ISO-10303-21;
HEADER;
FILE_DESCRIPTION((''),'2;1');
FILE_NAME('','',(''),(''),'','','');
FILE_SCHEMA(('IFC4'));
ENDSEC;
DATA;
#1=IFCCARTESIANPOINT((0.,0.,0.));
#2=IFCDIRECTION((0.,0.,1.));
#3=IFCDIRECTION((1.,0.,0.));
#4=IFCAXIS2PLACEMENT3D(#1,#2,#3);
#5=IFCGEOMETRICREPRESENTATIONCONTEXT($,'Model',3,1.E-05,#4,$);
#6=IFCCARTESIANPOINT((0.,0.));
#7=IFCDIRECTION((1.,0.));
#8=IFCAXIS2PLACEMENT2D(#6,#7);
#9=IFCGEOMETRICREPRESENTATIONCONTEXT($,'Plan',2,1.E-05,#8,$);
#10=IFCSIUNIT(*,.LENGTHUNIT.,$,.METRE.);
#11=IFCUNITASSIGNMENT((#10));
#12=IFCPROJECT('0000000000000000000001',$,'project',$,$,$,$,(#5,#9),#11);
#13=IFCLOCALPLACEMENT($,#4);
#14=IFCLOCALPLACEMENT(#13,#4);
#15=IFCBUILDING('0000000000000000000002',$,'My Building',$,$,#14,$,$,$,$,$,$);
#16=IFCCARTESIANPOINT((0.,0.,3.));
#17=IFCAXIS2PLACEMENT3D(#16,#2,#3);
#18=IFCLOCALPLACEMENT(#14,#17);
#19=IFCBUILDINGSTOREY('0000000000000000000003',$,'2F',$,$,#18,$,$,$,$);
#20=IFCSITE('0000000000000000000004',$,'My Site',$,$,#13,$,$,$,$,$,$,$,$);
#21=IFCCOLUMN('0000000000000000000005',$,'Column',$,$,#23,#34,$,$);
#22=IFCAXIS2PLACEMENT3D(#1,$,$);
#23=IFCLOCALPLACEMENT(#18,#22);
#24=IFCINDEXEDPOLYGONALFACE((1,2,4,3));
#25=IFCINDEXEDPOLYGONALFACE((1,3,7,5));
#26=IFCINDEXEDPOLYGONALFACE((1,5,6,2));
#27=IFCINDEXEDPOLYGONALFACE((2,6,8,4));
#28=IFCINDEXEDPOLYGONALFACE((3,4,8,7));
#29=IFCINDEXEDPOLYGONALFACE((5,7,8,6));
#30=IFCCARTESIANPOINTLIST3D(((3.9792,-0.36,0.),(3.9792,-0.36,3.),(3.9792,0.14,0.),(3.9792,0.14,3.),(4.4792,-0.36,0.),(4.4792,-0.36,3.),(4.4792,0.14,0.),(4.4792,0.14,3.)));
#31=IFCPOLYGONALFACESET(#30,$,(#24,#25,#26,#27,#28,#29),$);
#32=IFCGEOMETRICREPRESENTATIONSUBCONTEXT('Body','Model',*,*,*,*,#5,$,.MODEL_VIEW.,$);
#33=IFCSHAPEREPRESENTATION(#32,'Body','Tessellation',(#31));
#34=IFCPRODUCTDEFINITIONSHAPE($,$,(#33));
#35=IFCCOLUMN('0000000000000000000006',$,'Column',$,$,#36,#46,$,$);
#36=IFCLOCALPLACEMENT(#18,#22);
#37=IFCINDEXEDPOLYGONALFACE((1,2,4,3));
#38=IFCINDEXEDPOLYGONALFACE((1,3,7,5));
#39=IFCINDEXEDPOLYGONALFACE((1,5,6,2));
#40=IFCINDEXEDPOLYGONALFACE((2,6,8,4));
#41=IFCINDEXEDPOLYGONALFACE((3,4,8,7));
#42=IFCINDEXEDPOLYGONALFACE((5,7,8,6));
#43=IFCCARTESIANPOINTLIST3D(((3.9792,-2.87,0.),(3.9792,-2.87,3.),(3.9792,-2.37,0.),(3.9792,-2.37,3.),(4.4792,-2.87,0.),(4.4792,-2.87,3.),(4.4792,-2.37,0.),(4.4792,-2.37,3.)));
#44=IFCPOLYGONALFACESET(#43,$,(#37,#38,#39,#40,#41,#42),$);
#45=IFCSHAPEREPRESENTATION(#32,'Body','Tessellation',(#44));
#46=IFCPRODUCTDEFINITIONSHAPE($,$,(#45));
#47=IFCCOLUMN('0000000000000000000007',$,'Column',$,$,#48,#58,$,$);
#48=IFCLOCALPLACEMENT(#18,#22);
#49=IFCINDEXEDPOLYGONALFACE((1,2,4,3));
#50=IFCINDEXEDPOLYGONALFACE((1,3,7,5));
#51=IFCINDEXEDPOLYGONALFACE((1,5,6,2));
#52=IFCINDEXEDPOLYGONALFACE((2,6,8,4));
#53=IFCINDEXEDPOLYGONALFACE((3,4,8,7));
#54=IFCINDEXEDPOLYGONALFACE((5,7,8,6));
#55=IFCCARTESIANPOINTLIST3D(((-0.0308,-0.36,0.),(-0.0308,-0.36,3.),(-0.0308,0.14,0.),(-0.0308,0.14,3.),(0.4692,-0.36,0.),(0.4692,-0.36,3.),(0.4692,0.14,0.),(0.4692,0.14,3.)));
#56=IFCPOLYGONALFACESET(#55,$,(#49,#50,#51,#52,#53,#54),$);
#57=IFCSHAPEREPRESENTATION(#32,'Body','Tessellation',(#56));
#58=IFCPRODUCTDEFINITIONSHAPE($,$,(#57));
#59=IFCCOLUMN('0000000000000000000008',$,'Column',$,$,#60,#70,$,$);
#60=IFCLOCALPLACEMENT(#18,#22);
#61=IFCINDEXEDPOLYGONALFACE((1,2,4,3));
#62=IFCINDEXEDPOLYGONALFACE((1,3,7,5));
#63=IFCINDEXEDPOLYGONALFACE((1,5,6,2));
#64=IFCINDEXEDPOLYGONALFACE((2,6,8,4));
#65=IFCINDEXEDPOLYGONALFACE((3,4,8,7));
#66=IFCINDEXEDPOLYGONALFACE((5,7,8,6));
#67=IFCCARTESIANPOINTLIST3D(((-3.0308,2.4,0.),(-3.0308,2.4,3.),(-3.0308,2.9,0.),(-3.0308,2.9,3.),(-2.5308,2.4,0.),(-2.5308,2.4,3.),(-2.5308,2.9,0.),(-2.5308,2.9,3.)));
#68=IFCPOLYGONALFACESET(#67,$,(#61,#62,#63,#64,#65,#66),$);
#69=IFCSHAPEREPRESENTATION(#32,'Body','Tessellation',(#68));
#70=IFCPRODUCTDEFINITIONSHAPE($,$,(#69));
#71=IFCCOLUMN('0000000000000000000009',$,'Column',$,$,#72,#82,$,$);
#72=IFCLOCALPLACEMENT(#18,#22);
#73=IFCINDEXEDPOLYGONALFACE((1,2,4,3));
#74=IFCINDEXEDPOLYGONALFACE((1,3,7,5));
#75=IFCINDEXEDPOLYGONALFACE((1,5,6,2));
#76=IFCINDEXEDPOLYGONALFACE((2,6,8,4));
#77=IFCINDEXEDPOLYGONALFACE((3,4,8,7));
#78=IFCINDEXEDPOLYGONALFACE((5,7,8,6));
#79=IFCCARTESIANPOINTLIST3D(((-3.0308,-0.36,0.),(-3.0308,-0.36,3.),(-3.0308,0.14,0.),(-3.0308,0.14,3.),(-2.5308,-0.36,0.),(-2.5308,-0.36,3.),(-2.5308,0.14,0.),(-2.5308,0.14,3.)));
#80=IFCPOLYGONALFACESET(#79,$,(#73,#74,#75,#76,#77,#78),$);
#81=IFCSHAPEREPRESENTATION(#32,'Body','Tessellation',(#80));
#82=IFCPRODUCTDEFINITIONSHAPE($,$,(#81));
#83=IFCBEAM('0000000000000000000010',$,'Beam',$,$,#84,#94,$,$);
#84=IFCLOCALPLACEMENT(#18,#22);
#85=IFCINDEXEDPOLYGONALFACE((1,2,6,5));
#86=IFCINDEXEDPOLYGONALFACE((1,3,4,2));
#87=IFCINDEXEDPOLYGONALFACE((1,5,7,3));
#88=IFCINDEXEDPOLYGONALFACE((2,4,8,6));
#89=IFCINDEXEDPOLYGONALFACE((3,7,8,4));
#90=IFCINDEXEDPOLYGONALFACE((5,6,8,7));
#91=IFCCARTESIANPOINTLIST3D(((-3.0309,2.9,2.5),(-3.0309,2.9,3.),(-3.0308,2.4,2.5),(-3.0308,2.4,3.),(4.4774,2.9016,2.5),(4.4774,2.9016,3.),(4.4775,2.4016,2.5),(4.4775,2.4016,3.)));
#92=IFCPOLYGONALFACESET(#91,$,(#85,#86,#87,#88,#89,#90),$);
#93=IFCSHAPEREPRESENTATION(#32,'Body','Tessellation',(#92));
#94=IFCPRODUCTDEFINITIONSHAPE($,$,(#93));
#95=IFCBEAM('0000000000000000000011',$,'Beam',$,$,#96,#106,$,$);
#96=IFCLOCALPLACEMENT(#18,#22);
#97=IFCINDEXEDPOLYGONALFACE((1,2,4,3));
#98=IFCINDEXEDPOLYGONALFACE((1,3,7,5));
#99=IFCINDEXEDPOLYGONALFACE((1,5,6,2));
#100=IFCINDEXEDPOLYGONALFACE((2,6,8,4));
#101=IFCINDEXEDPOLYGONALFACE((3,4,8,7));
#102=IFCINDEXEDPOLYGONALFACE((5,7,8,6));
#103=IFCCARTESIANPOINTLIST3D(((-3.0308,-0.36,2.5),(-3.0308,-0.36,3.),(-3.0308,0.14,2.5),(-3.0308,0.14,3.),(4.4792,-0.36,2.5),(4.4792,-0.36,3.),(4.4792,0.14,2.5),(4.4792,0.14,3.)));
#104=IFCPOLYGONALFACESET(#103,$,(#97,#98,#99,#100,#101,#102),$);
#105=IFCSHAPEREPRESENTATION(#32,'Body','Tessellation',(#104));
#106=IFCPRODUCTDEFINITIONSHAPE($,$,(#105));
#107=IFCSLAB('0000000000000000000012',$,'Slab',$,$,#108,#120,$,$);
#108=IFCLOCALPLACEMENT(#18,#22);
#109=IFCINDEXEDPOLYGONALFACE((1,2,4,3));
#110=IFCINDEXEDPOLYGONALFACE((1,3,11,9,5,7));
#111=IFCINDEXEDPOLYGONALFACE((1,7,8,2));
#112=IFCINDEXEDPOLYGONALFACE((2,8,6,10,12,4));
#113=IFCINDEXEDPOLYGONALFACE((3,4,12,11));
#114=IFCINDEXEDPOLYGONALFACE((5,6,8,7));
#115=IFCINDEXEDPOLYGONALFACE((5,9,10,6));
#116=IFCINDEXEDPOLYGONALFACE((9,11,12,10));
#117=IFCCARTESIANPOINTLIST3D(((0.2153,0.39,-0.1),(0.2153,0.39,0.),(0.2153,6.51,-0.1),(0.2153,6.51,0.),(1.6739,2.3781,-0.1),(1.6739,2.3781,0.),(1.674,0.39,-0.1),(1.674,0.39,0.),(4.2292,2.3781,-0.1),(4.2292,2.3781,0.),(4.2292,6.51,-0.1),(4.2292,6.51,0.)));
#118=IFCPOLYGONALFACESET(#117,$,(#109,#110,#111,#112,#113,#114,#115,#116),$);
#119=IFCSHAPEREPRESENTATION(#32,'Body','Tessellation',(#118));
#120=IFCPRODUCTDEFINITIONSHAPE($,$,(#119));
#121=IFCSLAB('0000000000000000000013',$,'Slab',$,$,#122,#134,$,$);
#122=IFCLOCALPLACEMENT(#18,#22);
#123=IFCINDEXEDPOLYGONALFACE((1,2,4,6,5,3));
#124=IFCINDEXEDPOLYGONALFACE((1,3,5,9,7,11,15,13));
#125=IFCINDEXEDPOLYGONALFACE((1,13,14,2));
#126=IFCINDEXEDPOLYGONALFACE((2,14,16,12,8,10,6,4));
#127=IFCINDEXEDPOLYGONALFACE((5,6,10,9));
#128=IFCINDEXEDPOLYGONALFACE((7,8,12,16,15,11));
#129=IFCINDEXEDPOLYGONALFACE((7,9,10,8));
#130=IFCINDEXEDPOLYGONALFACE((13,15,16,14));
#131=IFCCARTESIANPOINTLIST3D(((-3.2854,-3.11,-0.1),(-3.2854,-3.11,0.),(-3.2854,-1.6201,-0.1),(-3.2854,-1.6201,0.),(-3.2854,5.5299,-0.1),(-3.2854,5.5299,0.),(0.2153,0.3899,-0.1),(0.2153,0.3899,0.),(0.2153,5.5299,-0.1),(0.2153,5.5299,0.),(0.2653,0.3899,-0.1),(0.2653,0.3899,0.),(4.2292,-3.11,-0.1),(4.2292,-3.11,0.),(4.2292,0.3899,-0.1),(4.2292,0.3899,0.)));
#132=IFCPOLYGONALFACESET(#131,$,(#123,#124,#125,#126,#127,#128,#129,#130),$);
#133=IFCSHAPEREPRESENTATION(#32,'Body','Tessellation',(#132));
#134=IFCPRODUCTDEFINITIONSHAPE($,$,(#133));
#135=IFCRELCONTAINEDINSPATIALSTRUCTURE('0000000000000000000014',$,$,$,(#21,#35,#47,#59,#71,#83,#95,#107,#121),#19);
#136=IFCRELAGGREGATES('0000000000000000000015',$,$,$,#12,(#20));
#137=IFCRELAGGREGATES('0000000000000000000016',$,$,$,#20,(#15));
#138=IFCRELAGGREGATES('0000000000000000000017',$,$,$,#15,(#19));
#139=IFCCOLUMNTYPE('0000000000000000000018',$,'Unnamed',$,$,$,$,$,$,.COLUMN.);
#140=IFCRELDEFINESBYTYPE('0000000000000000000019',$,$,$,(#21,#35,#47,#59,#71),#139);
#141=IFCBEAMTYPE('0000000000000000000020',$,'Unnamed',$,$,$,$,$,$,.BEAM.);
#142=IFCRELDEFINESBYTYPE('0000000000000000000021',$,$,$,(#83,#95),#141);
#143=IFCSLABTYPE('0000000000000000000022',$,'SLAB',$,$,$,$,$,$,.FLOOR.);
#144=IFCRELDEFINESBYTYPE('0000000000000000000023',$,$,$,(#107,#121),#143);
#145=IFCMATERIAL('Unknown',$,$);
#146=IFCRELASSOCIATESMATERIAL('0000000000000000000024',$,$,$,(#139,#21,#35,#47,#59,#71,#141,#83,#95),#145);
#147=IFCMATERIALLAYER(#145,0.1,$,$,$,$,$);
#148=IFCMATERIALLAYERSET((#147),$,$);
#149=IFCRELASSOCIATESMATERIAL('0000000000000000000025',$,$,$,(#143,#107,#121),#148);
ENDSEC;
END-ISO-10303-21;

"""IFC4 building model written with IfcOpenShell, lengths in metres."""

from ifc_helpers import new_model, si_unit, frame, origin_with_axes, origin_2d_with_axis, place, context, subcontext, project, spatial, indexed_curve, rectangle, outline, extrude, material, layer, layer_set, layer_usage, material_profile, profile_set, profile_usage, type_object, element, save


model = new_model("IFC4")

# Units and contexts
model_context = context("Model", 3, precision=1e-05, world=origin_with_axes())
plan_context = context("Plan", 2, precision=1e-05, world=origin_2d_with_axis())
body_context_1 = subcontext(model_context, "Body", "Model", "MODEL_VIEW")
ifc_project = project(units=[si_unit("LENGTHUNIT", "METRE")], contexts=[model_context, plan_context])

# Site, building, storey
site_placement = place(None, origin_with_axes())
site = spatial("IfcSite", under=ifc_project, at=site_placement, Name="My Site")
building_placement = place(site_placement, origin_with_axes())
building = spatial("IfcBuilding", under=site, at=building_placement, Name="My Building")
storey_placement = place(building_placement, frame((0.0, 0.0, 3.0), z_axis=(0.0, 0.0, 1.0), x_axis=(1.0, 0.0, 0.0)))
storey = spatial("IfcBuildingStorey", under=building, at=storey_placement, Name="2F")

# Columns
ifc_material = material(Name="Unknown")
ifc_material_profile_1 = material_profile(ifc_material, rectangle(XDim=0.5, YDim=0.5))
ifc_profile_set_1 = profile_set([ifc_material_profile_1])
ifc_profile_usage_1 = profile_usage(ifc_profile_set_1, cardinal=7)
column_type = type_object("IfcColumnType", Name="Unnamed", PredefinedType="COLUMN", material=ifc_profile_set_1)
column_1_placement = place(storey_placement, frame((4.4792, 0.14, 0.0), z_axis=(0.0, 0.0, 1.0), x_axis=(1.0, 0.0, 0.0)))
element("IfcColumn", 1, at=column_1_placement, inside=storey, type_object=column_type, material=ifc_profile_usage_1, Name="Column", context=body_context_1, shape_type="SweptSolid", body=[
    extrude(rectangle(XDim=0.5, YDim=0.5), frame((-0.25, -0.25, 0.0), z_axis=(0.0, 0.0, 1.0), x_axis=(1.0, 0.0, 0.0)), (0.0, 0.0, 1.0), 3.0),
])
ifc_profile_usage_2 = profile_usage(ifc_profile_set_1, cardinal=7)
column_2_placement = place(storey_placement, frame((4.4792, -2.37, 0.0), z_axis=(0.0, 0.0, 1.0), x_axis=(1.0, 0.0, 0.0)))
element("IfcColumn", 2, at=column_2_placement, inside=storey, type_object=column_type, material=ifc_profile_usage_2, Name="Column", context=body_context_1, shape_type="SweptSolid", body=[
    extrude(rectangle(XDim=0.5, YDim=0.5), frame((-0.25, -0.25, 0.0), z_axis=(0.0, 0.0, 1.0), x_axis=(1.0, 0.0, 0.0)), (0.0, 0.0, 1.0), 3.0),
])
ifc_profile_usage_3 = profile_usage(ifc_profile_set_1, cardinal=9)
column_3_placement = place(storey_placement, frame((-0.0308, 0.14, 0.0), z_axis=(0.0, 0.0, 1.0), x_axis=(1.0, 0.0, 0.0)))
element("IfcColumn", 3, at=column_3_placement, inside=storey, type_object=column_type, material=ifc_profile_usage_3, Name="Column", context=body_context_1, shape_type="SweptSolid", body=[
    extrude(rectangle(XDim=0.5, YDim=0.5), frame((0.25, -0.25, 0.0), z_axis=(0.0, 0.0, 1.0), x_axis=(1.0, 0.0, 0.0)), (0.0, 0.0, 1.0), 3.0),
])
ifc_profile_usage_4 = profile_usage(ifc_profile_set_1, cardinal=9)
column_4_placement = place(storey_placement, frame((-3.0308, 2.9, 0.0), z_axis=(0.0, 0.0, 1.0), x_axis=(1.0, 0.0, 0.0)))
element("IfcColumn", 4, at=column_4_placement, inside=storey, type_object=column_type, material=ifc_profile_usage_4, Name="Column", context=body_context_1, shape_type="SweptSolid", body=[
    extrude(rectangle(XDim=0.5, YDim=0.5), frame((0.25, -0.25, 0.0), z_axis=(0.0, 0.0, 1.0), x_axis=(1.0, 0.0, 0.0)), (0.0, 0.0, 1.0), 3.0),
])
ifc_profile_usage_5 = profile_usage(ifc_profile_set_1, cardinal=9)
column_5_placement = place(storey_placement, frame((-3.0308, 0.14, 0.0), z_axis=(0.0, 0.0, 1.0), x_axis=(1.0, 0.0, 0.0)))
element("IfcColumn", 5, at=column_5_placement, inside=storey, type_object=column_type, material=ifc_profile_usage_5, Name="Column", context=body_context_1, shape_type="SweptSolid", body=[
    extrude(rectangle(XDim=0.5, YDim=0.5), frame((0.25, -0.25, 0.0), z_axis=(0.0, 0.0, 1.0), x_axis=(1.0, 0.0, 0.0)), (0.0, 0.0, 1.0), 3.0),
])

# Beams
ifc_material_profile_2 = material_profile(ifc_material, rectangle(XDim=0.5, YDim=0.5))
ifc_profile_set_2 = profile_set([ifc_material_profile_2])
ifc_profile_usage_6 = profile_usage(ifc_profile_set_2, cardinal=9)
beam_type = type_object("IfcBeamType", Name="Unnamed", PredefinedType="BEAM", material=ifc_profile_set_2)
beam_1_placement = place(storey_placement, frame((-3.0308, 2.4, 3.0), z_axis=(1.0, 0.000217, 0.0), x_axis=(-0.000217, 1.0, 0.0)))
element("IfcBeam", 6, at=beam_1_placement, inside=storey, type_object=beam_type, material=ifc_profile_usage_6, Name="Beam", context=body_context_1, shape_type="SweptSolid", body=[
    extrude(rectangle(XDim=0.5, YDim=0.5), frame((0.25, -0.25, 0.0), z_axis=(0.0, 0.0, 1.0), x_axis=(1.0, 0.0, 0.0)), (0.0, 0.0, 1.0), 7.5083),
])
ifc_profile_usage_7 = profile_usage(ifc_profile_set_2, cardinal=9)
beam_2_placement = place(storey_placement, frame((-3.0308, -0.36, 3.0), z_axis=(1.0, 0.0, 0.0), x_axis=(0.0, 1.0, 0.0)))
element("IfcBeam", 7, at=beam_2_placement, inside=storey, type_object=beam_type, material=ifc_profile_usage_7, Name="Beam", context=body_context_1, shape_type="SweptSolid", body=[
    extrude(rectangle(XDim=0.5, YDim=0.5), frame((0.25, -0.25, 0.0), z_axis=(0.0, 0.0, 1.0), x_axis=(1.0, 0.0, 0.0)), (0.0, 0.0, 1.0), 7.51),
])

# Slabs
ifc_layer_1 = layer(ifc_material, 0.1)
ifc_layer_set_1 = layer_set([ifc_layer_1])
ifc_layer_usage_1 = layer_usage(ifc_layer_set_1, "AXIS3", "POSITIVE", -0.1)
slab_type = type_object("IfcSlabType", Name="SLAB", PredefinedType="FLOOR", material=ifc_layer_set_1)
slab_1_placement = place(storey_placement, frame((1.6739, 2.3781, 0.0), z_axis=(0.0, 0.0, 1.0), x_axis=(1.0, 0.0, 0.0)))
element("IfcSlab", 8, at=slab_1_placement, inside=storey, type_object=slab_type, material=ifc_layer_usage_1, Name="Slab", context=body_context_1, shape_type="SweptSolid", body=[
    extrude(outline(indexed_curve([(0.0, 0.0), (2.5552, 0.0), (2.5552, 4.1319), (-1.4586, 4.1319), (-1.4586, -1.9882), (0.0, -1.9882), (0.0, 0.0)])), frame((0.0, 0.0, -0.1), z_axis=(0.0, 0.0, 1.0), x_axis=(1.0, 0.0, 0.0)), (0.0, 0.0, 1.0), 0.1),
])
ifc_layer_usage_2 = layer_usage(ifc_layer_set_1, "AXIS3", "POSITIVE", -0.1)
slab_2_placement = place(storey_placement, frame((-3.2854, -1.6201, 0.0), z_axis=(0.0, 0.0, 1.0), x_axis=(1.0, 0.0, 0.0)))
element("IfcSlab", 9, at=slab_2_placement, inside=storey, type_object=slab_type, material=ifc_layer_usage_2, Name="Slab", context=body_context_1, shape_type="SweptSolid", body=[
    extrude(outline(indexed_curve([(0.0, 0.0), (0.0, -1.4899), (7.5146, -1.4899), (7.5146, 2.01), (3.5507, 2.01), (3.5007, 2.01), (3.5007, 7.15), (0.0, 7.15), (0.0, 0.0)])), frame((0.0, 0.0, -0.1), z_axis=(0.0, 0.0, 1.0), x_axis=(1.0, 0.0, 0.0)), (0.0, 0.0, 1.0), 0.1),
])

save(model, "model.ifc")
